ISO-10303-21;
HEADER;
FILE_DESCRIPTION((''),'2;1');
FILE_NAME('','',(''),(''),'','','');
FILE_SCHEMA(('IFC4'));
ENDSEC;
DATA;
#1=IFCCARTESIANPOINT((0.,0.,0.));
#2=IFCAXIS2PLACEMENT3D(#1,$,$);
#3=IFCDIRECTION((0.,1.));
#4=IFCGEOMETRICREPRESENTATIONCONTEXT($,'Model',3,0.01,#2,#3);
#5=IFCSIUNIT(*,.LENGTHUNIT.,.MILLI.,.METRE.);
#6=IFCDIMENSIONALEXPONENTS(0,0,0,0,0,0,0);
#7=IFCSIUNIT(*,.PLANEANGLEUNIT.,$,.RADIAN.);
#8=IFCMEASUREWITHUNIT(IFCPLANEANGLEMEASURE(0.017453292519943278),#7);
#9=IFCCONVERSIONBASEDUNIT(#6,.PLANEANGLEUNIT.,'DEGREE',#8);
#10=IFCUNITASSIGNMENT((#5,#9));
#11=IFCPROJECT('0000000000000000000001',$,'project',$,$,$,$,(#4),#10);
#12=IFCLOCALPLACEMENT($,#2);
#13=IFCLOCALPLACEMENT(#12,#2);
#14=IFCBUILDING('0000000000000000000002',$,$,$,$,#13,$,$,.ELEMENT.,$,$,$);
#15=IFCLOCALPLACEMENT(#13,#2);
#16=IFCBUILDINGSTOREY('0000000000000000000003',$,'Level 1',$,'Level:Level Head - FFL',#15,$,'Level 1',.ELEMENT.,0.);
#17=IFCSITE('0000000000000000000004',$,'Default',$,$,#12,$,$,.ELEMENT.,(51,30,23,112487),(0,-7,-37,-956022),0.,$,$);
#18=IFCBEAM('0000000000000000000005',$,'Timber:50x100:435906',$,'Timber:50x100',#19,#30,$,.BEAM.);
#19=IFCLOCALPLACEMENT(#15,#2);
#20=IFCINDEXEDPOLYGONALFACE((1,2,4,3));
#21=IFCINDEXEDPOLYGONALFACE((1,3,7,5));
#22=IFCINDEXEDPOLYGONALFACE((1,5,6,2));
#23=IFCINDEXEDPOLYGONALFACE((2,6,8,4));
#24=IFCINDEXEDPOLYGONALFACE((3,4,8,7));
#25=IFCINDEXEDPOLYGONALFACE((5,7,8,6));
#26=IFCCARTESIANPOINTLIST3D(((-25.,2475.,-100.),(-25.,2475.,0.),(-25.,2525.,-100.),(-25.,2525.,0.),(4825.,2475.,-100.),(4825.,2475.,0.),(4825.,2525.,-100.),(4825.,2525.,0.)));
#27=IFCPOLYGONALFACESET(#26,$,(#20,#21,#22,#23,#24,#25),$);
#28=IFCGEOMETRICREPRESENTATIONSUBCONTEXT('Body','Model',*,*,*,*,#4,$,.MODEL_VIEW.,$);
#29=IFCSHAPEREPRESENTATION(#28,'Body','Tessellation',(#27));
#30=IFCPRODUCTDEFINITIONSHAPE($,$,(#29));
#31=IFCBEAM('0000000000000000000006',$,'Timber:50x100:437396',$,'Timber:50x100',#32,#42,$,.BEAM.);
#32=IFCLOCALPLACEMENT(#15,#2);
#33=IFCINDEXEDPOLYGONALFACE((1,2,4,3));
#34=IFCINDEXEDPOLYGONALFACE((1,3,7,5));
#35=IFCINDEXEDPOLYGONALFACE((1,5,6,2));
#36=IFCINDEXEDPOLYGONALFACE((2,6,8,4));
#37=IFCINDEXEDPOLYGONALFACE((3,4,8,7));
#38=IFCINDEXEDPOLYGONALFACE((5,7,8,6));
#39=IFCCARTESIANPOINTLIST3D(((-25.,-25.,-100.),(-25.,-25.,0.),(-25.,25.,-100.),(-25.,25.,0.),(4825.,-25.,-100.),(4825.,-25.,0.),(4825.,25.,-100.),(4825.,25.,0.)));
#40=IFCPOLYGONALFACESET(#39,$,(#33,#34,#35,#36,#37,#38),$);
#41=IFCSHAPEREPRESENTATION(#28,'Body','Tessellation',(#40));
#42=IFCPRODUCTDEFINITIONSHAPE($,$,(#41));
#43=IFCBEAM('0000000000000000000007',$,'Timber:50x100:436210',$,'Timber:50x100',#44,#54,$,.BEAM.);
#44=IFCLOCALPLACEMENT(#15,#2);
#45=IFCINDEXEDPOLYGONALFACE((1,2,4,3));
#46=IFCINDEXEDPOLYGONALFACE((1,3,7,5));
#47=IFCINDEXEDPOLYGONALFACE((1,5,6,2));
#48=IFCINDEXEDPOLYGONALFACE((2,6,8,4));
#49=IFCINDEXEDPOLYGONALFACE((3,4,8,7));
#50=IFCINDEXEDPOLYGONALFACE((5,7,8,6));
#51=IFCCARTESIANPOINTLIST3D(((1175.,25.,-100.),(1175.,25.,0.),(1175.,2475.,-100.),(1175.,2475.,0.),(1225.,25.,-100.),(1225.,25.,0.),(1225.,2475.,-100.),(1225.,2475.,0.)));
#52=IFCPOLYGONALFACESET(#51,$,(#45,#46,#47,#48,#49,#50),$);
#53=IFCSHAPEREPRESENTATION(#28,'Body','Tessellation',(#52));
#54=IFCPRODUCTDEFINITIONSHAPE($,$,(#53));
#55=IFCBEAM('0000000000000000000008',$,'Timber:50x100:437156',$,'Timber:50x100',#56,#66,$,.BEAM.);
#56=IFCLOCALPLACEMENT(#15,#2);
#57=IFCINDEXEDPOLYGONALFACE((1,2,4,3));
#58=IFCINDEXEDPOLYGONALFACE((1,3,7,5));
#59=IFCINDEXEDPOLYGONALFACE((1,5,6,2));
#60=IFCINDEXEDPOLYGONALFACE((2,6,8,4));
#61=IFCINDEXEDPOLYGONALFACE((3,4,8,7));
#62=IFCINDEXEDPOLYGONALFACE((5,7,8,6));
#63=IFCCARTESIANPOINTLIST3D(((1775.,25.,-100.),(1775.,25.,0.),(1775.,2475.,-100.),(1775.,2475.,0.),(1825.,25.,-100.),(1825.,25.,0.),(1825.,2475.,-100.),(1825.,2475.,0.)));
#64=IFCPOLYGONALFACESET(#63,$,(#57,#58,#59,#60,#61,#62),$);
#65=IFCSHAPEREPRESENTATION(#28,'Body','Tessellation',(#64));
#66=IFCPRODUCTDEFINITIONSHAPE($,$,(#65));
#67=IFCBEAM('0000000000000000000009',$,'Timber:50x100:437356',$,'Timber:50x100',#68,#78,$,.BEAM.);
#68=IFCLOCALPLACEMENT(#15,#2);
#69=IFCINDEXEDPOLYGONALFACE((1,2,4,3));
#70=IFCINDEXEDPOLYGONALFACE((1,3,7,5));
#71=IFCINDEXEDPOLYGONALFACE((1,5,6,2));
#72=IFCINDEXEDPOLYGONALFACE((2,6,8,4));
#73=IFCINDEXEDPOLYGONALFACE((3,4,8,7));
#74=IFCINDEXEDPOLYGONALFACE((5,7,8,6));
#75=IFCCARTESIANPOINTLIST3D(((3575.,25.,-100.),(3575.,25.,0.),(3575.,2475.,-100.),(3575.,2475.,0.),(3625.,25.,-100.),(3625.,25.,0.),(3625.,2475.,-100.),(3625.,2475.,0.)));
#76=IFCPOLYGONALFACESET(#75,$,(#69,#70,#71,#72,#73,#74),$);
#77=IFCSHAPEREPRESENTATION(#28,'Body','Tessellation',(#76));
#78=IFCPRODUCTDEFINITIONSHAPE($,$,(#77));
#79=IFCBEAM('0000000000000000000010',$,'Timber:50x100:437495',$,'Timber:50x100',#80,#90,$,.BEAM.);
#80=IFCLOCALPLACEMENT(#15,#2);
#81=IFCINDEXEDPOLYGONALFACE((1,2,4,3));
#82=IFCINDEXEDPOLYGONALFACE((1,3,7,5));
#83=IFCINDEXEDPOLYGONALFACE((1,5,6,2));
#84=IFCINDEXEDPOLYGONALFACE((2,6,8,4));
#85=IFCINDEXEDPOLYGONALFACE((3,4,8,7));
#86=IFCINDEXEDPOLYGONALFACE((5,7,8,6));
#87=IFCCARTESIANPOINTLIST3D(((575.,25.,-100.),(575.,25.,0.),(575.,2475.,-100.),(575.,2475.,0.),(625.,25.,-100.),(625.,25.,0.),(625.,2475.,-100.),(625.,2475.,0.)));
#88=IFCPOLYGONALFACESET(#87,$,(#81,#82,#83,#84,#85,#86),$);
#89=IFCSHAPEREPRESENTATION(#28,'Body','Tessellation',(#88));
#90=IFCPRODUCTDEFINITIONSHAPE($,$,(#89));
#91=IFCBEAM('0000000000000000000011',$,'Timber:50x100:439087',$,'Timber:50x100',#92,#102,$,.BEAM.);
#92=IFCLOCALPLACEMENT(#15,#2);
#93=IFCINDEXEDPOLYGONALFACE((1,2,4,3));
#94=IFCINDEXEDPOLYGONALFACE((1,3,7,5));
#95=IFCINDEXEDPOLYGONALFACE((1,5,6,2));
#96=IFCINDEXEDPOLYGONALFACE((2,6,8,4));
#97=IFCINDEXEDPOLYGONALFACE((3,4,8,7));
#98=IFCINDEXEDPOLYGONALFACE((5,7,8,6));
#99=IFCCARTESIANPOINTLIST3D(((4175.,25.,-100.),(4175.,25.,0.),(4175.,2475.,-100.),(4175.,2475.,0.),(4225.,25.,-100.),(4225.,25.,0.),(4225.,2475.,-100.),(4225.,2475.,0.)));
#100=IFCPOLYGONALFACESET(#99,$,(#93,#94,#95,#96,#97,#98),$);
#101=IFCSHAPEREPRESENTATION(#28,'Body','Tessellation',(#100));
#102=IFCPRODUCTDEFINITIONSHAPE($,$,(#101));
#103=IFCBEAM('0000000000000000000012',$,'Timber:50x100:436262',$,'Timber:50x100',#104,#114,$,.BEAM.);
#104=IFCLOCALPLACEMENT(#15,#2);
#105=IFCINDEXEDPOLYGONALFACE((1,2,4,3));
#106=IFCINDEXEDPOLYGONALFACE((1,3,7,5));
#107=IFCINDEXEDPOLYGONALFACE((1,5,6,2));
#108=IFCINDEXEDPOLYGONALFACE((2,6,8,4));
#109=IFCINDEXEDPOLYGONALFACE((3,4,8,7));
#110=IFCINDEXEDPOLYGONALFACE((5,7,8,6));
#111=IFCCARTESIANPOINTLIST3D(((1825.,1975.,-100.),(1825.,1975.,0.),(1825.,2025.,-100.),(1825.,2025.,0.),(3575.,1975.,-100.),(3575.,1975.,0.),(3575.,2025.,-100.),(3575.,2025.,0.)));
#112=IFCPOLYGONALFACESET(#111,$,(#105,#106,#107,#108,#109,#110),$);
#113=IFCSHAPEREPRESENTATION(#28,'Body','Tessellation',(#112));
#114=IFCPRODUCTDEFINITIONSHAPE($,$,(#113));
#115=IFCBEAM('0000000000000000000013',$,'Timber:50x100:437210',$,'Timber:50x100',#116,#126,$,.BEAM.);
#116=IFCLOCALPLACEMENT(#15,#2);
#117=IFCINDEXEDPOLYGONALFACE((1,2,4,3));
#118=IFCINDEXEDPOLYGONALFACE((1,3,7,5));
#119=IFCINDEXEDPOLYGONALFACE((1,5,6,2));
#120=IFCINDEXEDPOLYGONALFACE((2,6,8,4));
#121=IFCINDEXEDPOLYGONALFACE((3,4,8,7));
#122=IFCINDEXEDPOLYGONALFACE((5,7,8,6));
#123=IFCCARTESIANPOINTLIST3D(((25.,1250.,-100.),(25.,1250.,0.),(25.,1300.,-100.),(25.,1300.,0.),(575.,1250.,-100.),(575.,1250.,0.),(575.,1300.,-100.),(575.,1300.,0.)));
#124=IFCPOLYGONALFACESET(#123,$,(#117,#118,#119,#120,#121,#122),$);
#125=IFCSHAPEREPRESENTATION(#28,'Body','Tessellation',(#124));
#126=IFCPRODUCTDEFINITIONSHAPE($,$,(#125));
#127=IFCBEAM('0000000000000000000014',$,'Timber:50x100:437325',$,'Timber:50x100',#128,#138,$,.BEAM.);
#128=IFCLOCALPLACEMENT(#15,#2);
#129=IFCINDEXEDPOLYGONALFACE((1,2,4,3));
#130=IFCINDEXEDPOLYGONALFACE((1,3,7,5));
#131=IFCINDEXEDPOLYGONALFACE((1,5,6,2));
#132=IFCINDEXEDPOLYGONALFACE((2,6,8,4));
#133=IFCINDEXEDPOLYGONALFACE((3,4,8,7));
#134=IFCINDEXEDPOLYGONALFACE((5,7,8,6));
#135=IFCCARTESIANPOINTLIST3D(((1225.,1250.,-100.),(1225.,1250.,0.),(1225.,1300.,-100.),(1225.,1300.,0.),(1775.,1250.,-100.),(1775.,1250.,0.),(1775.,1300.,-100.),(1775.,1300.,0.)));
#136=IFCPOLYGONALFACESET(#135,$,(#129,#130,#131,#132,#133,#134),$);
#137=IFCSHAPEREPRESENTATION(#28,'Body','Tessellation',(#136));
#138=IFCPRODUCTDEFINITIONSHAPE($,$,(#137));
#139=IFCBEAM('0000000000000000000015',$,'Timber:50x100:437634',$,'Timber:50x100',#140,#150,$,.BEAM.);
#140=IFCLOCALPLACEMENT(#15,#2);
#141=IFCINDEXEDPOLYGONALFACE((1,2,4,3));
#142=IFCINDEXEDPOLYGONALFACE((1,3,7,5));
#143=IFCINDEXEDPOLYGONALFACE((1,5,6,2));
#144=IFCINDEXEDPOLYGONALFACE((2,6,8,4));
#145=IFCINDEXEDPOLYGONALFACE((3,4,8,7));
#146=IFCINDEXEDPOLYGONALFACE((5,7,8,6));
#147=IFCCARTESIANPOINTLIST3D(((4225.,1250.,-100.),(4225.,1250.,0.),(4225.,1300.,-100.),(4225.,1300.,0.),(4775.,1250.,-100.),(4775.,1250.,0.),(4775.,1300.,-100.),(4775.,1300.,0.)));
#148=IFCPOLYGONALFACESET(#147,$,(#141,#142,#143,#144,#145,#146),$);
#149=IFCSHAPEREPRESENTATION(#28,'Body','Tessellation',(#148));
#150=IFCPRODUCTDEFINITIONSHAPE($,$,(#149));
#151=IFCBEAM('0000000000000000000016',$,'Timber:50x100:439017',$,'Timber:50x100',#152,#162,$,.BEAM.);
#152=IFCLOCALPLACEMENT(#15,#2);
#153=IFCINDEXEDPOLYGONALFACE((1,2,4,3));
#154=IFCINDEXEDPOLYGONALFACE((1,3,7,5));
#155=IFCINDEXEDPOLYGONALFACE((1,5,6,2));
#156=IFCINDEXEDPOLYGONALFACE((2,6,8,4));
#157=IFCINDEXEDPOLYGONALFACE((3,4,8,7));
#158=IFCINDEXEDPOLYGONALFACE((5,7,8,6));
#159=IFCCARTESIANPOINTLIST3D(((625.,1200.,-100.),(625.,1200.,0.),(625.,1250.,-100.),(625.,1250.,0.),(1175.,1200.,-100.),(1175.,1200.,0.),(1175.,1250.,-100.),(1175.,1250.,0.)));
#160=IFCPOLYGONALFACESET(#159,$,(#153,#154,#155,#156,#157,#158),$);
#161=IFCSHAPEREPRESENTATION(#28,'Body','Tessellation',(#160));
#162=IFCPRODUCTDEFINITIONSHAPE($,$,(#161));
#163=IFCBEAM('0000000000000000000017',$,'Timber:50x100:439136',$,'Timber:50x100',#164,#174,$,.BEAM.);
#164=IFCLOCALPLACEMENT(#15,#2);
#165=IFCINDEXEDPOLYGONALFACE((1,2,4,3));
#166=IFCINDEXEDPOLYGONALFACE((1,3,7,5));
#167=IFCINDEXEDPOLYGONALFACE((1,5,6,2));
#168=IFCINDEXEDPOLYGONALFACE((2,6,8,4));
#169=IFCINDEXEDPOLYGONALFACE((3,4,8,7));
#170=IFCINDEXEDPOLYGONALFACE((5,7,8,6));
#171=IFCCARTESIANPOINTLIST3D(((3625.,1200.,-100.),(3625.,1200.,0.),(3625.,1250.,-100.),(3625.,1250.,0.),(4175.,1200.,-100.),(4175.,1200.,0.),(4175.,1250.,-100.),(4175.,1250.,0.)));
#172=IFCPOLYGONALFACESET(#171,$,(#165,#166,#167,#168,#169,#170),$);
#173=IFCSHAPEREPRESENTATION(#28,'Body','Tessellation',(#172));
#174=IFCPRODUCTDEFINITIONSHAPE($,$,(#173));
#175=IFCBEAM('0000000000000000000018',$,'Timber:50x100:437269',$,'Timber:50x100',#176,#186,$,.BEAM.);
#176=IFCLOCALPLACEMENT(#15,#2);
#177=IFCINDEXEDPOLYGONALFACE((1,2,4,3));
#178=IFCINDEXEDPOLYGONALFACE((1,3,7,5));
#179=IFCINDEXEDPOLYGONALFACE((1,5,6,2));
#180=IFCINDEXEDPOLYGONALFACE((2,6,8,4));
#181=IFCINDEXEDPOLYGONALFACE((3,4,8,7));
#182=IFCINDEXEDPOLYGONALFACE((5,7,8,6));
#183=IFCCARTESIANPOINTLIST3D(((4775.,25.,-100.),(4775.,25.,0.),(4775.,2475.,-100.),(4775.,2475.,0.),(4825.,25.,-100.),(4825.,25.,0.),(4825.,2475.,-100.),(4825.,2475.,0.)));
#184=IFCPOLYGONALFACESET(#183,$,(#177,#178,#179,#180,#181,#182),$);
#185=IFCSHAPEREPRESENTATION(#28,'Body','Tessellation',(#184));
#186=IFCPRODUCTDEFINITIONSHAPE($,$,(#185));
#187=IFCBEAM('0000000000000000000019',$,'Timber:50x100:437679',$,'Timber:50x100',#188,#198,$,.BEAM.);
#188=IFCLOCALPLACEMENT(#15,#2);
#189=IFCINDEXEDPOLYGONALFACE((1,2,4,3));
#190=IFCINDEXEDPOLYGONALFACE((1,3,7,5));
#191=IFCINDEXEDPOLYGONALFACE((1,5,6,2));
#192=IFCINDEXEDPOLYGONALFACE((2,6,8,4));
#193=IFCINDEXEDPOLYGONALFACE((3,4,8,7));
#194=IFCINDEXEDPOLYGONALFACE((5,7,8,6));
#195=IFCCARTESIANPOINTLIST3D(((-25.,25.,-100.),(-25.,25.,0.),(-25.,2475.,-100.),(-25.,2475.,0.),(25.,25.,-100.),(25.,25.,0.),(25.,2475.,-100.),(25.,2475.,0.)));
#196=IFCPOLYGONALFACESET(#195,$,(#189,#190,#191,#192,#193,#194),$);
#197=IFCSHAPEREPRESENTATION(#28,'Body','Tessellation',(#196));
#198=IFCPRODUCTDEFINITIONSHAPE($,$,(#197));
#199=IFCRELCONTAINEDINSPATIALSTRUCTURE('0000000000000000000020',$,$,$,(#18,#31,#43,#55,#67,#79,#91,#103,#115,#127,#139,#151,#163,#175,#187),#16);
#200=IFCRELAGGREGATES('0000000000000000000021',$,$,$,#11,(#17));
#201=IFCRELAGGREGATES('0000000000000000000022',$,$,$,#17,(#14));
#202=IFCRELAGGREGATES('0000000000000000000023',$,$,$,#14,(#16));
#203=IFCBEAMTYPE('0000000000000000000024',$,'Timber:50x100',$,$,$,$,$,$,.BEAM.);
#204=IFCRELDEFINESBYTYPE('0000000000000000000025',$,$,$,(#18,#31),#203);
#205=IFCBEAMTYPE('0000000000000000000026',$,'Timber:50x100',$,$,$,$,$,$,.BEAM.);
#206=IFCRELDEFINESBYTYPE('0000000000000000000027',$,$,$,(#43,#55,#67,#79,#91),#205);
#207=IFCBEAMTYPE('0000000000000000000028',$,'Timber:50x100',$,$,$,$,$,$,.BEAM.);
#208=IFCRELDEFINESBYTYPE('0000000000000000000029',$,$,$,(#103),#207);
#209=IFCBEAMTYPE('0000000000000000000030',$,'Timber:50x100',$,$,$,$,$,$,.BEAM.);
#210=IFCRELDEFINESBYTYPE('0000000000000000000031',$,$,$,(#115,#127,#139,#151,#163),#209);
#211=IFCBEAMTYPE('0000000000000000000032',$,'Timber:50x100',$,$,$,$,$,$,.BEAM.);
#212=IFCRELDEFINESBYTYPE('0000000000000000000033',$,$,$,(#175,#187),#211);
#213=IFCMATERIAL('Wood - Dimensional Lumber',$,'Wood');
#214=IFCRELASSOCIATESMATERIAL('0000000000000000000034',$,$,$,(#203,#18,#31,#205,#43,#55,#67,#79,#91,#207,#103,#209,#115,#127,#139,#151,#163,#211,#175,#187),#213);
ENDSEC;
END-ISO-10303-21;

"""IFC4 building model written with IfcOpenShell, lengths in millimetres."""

from ifc_helpers import new_model, entity, si_unit, converted_unit, direction, frame, origin, place, context, subcontext, project, spatial, indexed_curve, outline, extrude, source, transform, mapped, material, type_object, type_shapes, element, save


model = new_model("IFC4")

# Units and contexts
model_context = context("Model", 3, precision=0.01, world=origin(), true_north=direction((0.0, 1.0)))
body_context = subcontext(model_context, "Body", "Model", "MODEL_VIEW")
ifc_project = project(units=[si_unit("LENGTHUNIT", "METRE", prefix="MILLI"), converted_unit("PLANEANGLEUNIT", "DEGREE", entity("IfcPlaneAngleMeasure", 0.017453292519943278), si_unit("PLANEANGLEUNIT", "RADIAN"), dimensions=[0, 0, 0, 0, 0, 0, 0])], contexts=[model_context])

# Site, building, storey
site_placement = place(None, origin())
site = spatial("IfcSite", under=ifc_project, at=site_placement, Name="Default", CompositionType="ELEMENT", RefLatitude=(51, 30, 23, 112487), RefLongitude=(0, -7, -37, -956022), RefElevation=0.0)
building_placement = place(site_placement, origin())
building = spatial("IfcBuilding", under=site, at=building_placement, CompositionType="ELEMENT")
storey_placement = place(building_placement, origin())
storey = spatial("IfcBuildingStorey", under=building, at=storey_placement, Name="Level 1", ObjectType="Level:Level Head - FFL", LongName="Level 1", CompositionType="ELEMENT", Elevation=0.0)

# Beams
ifc_material = material(Name="Wood - Dimensional Lumber", Category="Wood")
beam_type_1 = type_object("IfcBeamType", Name="Timber:50x100", PredefinedType="BEAM", material=ifc_material)
shared_shape_1 = source(origin(), body_context, "Body", "SweptSolid", [
    extrude(outline(indexed_curve([(-2425.0, -25.0), (2425.0, -25.0), (2425.0, 25.0), (-2425.0, 25.0), (-2425.0, -25.0)], self_intersect=False)), frame((0.0, 0.0, -50.0), z_axis=(0.0, 0.0, 1.0), x_axis=(-1.0, 0.0, 0.0)), (0.0, 0.0, 1.0), 100.0),
])
type_shapes(beam_type_1, [shared_shape_1])
for number, where, name in (
    (1, (2400.0, 2500.0, -50.0), "Timber:50x100:435906"),
    (2, (2400.0, 0.0, -50.0), "Timber:50x100:437396"),
):
    element("IfcBeam", number, at=place(storey_placement, frame(where)), inside=storey, type_object=beam_type_1, material=ifc_material, Name=name, ObjectType="Timber:50x100", PredefinedType="BEAM", context=body_context, shape_type="MappedRepresentation", body=[
        mapped(shared_shape_1, transform((0.0, 0.0, 0.0), scale=1.0)),
    ])
beam_type_2 = type_object("IfcBeamType", Name="Timber:50x100", PredefinedType="BEAM", material=ifc_material)
shared_shape_2 = source(origin(), body_context, "Body", "SweptSolid", [
    extrude(outline(indexed_curve([(-1225.0, -25.0), (1225.0, -25.0), (1225.0, 25.0), (-1225.0, 25.0), (-1225.0, -25.0)], self_intersect=False)), frame((0.0, 0.0, -50.0), z_axis=(0.0, 0.0, 1.0), x_axis=(-1.0, 0.0, 0.0)), (0.0, 0.0, 1.0), 100.0),
])
type_shapes(beam_type_2, [shared_shape_2])
for number, where, z_axis, x_axis, name in (
    (3, (1200.0, 1250.0, -50.0), (0.0, 0.0, 1.0), (0.0, -1.0, 0.0), "Timber:50x100:436210"),
    (4, (1800.0, 1250.0, -50.0), (0.0, 0.0, 1.0), (0.0, -1.0, 0.0), "Timber:50x100:437156"),
    (5, (3600.0, 1250.0, -50.0), (0.0, 0.0, 1.0), (0.0, -1.0, 0.0), "Timber:50x100:437356"),
    (6, (600.0, 1250.0, -50.0), (0.0, 0.0, 1.0), (0.0, -1.0, 0.0), "Timber:50x100:437495"),
    (7, (4200.0, 1250.0, -50.0), (0.0, 0.0, 1.0), (0.0, -1.0, 0.0), "Timber:50x100:439087"),
):
    element("IfcBeam", number, at=place(storey_placement, frame(where, z_axis=z_axis, x_axis=x_axis)), inside=storey, type_object=beam_type_2, material=ifc_material, Name=name, ObjectType="Timber:50x100", PredefinedType="BEAM", context=body_context, shape_type="MappedRepresentation", body=[
        mapped(shared_shape_2, transform((0.0, 0.0, 0.0), scale=1.0)),
    ])
beam_type_3 = type_object("IfcBeamType", Name="Timber:50x100", PredefinedType="BEAM", material=ifc_material)
shared_shape_3 = source(origin(), body_context, "Body", "SweptSolid", [
    extrude(outline(indexed_curve([(-875.0, -25.0), (875.0, -25.0), (875.0, 25.0), (-875.0, 25.0), (-875.0, -25.0)], self_intersect=False)), frame((0.0, 0.0, -50.0), z_axis=(0.0, 0.0, 1.0), x_axis=(-1.0, 0.0, 0.0)), (0.0, 0.0, 1.0), 100.0),
])
type_shapes(beam_type_3, [shared_shape_3])
beam_placement = place(storey_placement, frame((2700.0, 2000.0, -50.0)))
element("IfcBeam", 8, at=beam_placement, inside=storey, type_object=beam_type_3, material=ifc_material, Name="Timber:50x100:436262", ObjectType="Timber:50x100", PredefinedType="BEAM", context=body_context, shape_type="MappedRepresentation", body=[
    mapped(shared_shape_3, transform((0.0, 0.0, 0.0), scale=1.0)),
])
beam_type_4 = type_object("IfcBeamType", Name="Timber:50x100", PredefinedType="BEAM", material=ifc_material)
shared_shape_4 = source(origin(), body_context, "Body", "SweptSolid", [
    extrude(outline(indexed_curve([(-275.0, -25.0), (275.0, -25.0), (275.0, 25.0), (-275.0, 25.0), (-275.0, -25.0)], self_intersect=False)), frame((0.0, 0.0, -50.0), z_axis=(0.0, 0.0, 1.0), x_axis=(-1.0, 0.0, 0.0)), (0.0, 0.0, 1.0), 100.0),
])
type_shapes(beam_type_4, [shared_shape_4])
for number, where, name in (
    (9, (300.0, 1275.0, -50.0), "Timber:50x100:437210"),
    (10, (1500.0, 1275.0, -50.0), "Timber:50x100:437325"),
    (11, (4500.0, 1275.0, -50.0), "Timber:50x100:437634"),
    (12, (900.0, 1225.0, -50.0), "Timber:50x100:439017"),
    (13, (3900.0, 1225.0, -50.0), "Timber:50x100:439136"),
):
    element("IfcBeam", number, at=place(storey_placement, frame(where)), inside=storey, type_object=beam_type_4, material=ifc_material, Name=name, ObjectType="Timber:50x100", PredefinedType="BEAM", context=body_context, shape_type="MappedRepresentation", body=[
        mapped(shared_shape_4, transform((0.0, 0.0, 0.0), scale=1.0)),
    ])
beam_type_5 = type_object("IfcBeamType", Name="Timber:50x100", PredefinedType="BEAM", material=ifc_material)
shared_shape_5 = source(origin(), body_context, "Body", "SweptSolid", [
    extrude(outline(indexed_curve([(-1225.0, -25.0), (1225.0, -25.0), (1225.0, 25.0), (-1225.0, 25.0), (-1225.0, -25.0)], self_intersect=False)), frame((0.0, 0.0, -50.0), z_axis=(0.0, 0.0, 1.0), x_axis=(-1.0, 0.0, 0.0)), (0.0, 0.0, 1.0), 100.0),
])
type_shapes(beam_type_5, [shared_shape_5])
for number, where, z_axis, x_axis, name in (
    (14, (4800.0, 1250.0, -50.0), (0.0, 0.0, 1.0), (0.0, -1.0, 0.0), "Timber:50x100:437269"),
    (15, (0.0, 1250.0, -50.0), (0.0, 0.0, 1.0), (0.0, -1.0, 0.0), "Timber:50x100:437679"),
):
    element("IfcBeam", number, at=place(storey_placement, frame(where, z_axis=z_axis, x_axis=x_axis)), inside=storey, type_object=beam_type_5, material=ifc_material, Name=name, ObjectType="Timber:50x100", PredefinedType="BEAM", context=body_context, shape_type="MappedRepresentation", body=[
        mapped(shared_shape_5, transform((0.0, 0.0, 0.0), scale=1.0)),
    ])

save(model, "model.ifc")
